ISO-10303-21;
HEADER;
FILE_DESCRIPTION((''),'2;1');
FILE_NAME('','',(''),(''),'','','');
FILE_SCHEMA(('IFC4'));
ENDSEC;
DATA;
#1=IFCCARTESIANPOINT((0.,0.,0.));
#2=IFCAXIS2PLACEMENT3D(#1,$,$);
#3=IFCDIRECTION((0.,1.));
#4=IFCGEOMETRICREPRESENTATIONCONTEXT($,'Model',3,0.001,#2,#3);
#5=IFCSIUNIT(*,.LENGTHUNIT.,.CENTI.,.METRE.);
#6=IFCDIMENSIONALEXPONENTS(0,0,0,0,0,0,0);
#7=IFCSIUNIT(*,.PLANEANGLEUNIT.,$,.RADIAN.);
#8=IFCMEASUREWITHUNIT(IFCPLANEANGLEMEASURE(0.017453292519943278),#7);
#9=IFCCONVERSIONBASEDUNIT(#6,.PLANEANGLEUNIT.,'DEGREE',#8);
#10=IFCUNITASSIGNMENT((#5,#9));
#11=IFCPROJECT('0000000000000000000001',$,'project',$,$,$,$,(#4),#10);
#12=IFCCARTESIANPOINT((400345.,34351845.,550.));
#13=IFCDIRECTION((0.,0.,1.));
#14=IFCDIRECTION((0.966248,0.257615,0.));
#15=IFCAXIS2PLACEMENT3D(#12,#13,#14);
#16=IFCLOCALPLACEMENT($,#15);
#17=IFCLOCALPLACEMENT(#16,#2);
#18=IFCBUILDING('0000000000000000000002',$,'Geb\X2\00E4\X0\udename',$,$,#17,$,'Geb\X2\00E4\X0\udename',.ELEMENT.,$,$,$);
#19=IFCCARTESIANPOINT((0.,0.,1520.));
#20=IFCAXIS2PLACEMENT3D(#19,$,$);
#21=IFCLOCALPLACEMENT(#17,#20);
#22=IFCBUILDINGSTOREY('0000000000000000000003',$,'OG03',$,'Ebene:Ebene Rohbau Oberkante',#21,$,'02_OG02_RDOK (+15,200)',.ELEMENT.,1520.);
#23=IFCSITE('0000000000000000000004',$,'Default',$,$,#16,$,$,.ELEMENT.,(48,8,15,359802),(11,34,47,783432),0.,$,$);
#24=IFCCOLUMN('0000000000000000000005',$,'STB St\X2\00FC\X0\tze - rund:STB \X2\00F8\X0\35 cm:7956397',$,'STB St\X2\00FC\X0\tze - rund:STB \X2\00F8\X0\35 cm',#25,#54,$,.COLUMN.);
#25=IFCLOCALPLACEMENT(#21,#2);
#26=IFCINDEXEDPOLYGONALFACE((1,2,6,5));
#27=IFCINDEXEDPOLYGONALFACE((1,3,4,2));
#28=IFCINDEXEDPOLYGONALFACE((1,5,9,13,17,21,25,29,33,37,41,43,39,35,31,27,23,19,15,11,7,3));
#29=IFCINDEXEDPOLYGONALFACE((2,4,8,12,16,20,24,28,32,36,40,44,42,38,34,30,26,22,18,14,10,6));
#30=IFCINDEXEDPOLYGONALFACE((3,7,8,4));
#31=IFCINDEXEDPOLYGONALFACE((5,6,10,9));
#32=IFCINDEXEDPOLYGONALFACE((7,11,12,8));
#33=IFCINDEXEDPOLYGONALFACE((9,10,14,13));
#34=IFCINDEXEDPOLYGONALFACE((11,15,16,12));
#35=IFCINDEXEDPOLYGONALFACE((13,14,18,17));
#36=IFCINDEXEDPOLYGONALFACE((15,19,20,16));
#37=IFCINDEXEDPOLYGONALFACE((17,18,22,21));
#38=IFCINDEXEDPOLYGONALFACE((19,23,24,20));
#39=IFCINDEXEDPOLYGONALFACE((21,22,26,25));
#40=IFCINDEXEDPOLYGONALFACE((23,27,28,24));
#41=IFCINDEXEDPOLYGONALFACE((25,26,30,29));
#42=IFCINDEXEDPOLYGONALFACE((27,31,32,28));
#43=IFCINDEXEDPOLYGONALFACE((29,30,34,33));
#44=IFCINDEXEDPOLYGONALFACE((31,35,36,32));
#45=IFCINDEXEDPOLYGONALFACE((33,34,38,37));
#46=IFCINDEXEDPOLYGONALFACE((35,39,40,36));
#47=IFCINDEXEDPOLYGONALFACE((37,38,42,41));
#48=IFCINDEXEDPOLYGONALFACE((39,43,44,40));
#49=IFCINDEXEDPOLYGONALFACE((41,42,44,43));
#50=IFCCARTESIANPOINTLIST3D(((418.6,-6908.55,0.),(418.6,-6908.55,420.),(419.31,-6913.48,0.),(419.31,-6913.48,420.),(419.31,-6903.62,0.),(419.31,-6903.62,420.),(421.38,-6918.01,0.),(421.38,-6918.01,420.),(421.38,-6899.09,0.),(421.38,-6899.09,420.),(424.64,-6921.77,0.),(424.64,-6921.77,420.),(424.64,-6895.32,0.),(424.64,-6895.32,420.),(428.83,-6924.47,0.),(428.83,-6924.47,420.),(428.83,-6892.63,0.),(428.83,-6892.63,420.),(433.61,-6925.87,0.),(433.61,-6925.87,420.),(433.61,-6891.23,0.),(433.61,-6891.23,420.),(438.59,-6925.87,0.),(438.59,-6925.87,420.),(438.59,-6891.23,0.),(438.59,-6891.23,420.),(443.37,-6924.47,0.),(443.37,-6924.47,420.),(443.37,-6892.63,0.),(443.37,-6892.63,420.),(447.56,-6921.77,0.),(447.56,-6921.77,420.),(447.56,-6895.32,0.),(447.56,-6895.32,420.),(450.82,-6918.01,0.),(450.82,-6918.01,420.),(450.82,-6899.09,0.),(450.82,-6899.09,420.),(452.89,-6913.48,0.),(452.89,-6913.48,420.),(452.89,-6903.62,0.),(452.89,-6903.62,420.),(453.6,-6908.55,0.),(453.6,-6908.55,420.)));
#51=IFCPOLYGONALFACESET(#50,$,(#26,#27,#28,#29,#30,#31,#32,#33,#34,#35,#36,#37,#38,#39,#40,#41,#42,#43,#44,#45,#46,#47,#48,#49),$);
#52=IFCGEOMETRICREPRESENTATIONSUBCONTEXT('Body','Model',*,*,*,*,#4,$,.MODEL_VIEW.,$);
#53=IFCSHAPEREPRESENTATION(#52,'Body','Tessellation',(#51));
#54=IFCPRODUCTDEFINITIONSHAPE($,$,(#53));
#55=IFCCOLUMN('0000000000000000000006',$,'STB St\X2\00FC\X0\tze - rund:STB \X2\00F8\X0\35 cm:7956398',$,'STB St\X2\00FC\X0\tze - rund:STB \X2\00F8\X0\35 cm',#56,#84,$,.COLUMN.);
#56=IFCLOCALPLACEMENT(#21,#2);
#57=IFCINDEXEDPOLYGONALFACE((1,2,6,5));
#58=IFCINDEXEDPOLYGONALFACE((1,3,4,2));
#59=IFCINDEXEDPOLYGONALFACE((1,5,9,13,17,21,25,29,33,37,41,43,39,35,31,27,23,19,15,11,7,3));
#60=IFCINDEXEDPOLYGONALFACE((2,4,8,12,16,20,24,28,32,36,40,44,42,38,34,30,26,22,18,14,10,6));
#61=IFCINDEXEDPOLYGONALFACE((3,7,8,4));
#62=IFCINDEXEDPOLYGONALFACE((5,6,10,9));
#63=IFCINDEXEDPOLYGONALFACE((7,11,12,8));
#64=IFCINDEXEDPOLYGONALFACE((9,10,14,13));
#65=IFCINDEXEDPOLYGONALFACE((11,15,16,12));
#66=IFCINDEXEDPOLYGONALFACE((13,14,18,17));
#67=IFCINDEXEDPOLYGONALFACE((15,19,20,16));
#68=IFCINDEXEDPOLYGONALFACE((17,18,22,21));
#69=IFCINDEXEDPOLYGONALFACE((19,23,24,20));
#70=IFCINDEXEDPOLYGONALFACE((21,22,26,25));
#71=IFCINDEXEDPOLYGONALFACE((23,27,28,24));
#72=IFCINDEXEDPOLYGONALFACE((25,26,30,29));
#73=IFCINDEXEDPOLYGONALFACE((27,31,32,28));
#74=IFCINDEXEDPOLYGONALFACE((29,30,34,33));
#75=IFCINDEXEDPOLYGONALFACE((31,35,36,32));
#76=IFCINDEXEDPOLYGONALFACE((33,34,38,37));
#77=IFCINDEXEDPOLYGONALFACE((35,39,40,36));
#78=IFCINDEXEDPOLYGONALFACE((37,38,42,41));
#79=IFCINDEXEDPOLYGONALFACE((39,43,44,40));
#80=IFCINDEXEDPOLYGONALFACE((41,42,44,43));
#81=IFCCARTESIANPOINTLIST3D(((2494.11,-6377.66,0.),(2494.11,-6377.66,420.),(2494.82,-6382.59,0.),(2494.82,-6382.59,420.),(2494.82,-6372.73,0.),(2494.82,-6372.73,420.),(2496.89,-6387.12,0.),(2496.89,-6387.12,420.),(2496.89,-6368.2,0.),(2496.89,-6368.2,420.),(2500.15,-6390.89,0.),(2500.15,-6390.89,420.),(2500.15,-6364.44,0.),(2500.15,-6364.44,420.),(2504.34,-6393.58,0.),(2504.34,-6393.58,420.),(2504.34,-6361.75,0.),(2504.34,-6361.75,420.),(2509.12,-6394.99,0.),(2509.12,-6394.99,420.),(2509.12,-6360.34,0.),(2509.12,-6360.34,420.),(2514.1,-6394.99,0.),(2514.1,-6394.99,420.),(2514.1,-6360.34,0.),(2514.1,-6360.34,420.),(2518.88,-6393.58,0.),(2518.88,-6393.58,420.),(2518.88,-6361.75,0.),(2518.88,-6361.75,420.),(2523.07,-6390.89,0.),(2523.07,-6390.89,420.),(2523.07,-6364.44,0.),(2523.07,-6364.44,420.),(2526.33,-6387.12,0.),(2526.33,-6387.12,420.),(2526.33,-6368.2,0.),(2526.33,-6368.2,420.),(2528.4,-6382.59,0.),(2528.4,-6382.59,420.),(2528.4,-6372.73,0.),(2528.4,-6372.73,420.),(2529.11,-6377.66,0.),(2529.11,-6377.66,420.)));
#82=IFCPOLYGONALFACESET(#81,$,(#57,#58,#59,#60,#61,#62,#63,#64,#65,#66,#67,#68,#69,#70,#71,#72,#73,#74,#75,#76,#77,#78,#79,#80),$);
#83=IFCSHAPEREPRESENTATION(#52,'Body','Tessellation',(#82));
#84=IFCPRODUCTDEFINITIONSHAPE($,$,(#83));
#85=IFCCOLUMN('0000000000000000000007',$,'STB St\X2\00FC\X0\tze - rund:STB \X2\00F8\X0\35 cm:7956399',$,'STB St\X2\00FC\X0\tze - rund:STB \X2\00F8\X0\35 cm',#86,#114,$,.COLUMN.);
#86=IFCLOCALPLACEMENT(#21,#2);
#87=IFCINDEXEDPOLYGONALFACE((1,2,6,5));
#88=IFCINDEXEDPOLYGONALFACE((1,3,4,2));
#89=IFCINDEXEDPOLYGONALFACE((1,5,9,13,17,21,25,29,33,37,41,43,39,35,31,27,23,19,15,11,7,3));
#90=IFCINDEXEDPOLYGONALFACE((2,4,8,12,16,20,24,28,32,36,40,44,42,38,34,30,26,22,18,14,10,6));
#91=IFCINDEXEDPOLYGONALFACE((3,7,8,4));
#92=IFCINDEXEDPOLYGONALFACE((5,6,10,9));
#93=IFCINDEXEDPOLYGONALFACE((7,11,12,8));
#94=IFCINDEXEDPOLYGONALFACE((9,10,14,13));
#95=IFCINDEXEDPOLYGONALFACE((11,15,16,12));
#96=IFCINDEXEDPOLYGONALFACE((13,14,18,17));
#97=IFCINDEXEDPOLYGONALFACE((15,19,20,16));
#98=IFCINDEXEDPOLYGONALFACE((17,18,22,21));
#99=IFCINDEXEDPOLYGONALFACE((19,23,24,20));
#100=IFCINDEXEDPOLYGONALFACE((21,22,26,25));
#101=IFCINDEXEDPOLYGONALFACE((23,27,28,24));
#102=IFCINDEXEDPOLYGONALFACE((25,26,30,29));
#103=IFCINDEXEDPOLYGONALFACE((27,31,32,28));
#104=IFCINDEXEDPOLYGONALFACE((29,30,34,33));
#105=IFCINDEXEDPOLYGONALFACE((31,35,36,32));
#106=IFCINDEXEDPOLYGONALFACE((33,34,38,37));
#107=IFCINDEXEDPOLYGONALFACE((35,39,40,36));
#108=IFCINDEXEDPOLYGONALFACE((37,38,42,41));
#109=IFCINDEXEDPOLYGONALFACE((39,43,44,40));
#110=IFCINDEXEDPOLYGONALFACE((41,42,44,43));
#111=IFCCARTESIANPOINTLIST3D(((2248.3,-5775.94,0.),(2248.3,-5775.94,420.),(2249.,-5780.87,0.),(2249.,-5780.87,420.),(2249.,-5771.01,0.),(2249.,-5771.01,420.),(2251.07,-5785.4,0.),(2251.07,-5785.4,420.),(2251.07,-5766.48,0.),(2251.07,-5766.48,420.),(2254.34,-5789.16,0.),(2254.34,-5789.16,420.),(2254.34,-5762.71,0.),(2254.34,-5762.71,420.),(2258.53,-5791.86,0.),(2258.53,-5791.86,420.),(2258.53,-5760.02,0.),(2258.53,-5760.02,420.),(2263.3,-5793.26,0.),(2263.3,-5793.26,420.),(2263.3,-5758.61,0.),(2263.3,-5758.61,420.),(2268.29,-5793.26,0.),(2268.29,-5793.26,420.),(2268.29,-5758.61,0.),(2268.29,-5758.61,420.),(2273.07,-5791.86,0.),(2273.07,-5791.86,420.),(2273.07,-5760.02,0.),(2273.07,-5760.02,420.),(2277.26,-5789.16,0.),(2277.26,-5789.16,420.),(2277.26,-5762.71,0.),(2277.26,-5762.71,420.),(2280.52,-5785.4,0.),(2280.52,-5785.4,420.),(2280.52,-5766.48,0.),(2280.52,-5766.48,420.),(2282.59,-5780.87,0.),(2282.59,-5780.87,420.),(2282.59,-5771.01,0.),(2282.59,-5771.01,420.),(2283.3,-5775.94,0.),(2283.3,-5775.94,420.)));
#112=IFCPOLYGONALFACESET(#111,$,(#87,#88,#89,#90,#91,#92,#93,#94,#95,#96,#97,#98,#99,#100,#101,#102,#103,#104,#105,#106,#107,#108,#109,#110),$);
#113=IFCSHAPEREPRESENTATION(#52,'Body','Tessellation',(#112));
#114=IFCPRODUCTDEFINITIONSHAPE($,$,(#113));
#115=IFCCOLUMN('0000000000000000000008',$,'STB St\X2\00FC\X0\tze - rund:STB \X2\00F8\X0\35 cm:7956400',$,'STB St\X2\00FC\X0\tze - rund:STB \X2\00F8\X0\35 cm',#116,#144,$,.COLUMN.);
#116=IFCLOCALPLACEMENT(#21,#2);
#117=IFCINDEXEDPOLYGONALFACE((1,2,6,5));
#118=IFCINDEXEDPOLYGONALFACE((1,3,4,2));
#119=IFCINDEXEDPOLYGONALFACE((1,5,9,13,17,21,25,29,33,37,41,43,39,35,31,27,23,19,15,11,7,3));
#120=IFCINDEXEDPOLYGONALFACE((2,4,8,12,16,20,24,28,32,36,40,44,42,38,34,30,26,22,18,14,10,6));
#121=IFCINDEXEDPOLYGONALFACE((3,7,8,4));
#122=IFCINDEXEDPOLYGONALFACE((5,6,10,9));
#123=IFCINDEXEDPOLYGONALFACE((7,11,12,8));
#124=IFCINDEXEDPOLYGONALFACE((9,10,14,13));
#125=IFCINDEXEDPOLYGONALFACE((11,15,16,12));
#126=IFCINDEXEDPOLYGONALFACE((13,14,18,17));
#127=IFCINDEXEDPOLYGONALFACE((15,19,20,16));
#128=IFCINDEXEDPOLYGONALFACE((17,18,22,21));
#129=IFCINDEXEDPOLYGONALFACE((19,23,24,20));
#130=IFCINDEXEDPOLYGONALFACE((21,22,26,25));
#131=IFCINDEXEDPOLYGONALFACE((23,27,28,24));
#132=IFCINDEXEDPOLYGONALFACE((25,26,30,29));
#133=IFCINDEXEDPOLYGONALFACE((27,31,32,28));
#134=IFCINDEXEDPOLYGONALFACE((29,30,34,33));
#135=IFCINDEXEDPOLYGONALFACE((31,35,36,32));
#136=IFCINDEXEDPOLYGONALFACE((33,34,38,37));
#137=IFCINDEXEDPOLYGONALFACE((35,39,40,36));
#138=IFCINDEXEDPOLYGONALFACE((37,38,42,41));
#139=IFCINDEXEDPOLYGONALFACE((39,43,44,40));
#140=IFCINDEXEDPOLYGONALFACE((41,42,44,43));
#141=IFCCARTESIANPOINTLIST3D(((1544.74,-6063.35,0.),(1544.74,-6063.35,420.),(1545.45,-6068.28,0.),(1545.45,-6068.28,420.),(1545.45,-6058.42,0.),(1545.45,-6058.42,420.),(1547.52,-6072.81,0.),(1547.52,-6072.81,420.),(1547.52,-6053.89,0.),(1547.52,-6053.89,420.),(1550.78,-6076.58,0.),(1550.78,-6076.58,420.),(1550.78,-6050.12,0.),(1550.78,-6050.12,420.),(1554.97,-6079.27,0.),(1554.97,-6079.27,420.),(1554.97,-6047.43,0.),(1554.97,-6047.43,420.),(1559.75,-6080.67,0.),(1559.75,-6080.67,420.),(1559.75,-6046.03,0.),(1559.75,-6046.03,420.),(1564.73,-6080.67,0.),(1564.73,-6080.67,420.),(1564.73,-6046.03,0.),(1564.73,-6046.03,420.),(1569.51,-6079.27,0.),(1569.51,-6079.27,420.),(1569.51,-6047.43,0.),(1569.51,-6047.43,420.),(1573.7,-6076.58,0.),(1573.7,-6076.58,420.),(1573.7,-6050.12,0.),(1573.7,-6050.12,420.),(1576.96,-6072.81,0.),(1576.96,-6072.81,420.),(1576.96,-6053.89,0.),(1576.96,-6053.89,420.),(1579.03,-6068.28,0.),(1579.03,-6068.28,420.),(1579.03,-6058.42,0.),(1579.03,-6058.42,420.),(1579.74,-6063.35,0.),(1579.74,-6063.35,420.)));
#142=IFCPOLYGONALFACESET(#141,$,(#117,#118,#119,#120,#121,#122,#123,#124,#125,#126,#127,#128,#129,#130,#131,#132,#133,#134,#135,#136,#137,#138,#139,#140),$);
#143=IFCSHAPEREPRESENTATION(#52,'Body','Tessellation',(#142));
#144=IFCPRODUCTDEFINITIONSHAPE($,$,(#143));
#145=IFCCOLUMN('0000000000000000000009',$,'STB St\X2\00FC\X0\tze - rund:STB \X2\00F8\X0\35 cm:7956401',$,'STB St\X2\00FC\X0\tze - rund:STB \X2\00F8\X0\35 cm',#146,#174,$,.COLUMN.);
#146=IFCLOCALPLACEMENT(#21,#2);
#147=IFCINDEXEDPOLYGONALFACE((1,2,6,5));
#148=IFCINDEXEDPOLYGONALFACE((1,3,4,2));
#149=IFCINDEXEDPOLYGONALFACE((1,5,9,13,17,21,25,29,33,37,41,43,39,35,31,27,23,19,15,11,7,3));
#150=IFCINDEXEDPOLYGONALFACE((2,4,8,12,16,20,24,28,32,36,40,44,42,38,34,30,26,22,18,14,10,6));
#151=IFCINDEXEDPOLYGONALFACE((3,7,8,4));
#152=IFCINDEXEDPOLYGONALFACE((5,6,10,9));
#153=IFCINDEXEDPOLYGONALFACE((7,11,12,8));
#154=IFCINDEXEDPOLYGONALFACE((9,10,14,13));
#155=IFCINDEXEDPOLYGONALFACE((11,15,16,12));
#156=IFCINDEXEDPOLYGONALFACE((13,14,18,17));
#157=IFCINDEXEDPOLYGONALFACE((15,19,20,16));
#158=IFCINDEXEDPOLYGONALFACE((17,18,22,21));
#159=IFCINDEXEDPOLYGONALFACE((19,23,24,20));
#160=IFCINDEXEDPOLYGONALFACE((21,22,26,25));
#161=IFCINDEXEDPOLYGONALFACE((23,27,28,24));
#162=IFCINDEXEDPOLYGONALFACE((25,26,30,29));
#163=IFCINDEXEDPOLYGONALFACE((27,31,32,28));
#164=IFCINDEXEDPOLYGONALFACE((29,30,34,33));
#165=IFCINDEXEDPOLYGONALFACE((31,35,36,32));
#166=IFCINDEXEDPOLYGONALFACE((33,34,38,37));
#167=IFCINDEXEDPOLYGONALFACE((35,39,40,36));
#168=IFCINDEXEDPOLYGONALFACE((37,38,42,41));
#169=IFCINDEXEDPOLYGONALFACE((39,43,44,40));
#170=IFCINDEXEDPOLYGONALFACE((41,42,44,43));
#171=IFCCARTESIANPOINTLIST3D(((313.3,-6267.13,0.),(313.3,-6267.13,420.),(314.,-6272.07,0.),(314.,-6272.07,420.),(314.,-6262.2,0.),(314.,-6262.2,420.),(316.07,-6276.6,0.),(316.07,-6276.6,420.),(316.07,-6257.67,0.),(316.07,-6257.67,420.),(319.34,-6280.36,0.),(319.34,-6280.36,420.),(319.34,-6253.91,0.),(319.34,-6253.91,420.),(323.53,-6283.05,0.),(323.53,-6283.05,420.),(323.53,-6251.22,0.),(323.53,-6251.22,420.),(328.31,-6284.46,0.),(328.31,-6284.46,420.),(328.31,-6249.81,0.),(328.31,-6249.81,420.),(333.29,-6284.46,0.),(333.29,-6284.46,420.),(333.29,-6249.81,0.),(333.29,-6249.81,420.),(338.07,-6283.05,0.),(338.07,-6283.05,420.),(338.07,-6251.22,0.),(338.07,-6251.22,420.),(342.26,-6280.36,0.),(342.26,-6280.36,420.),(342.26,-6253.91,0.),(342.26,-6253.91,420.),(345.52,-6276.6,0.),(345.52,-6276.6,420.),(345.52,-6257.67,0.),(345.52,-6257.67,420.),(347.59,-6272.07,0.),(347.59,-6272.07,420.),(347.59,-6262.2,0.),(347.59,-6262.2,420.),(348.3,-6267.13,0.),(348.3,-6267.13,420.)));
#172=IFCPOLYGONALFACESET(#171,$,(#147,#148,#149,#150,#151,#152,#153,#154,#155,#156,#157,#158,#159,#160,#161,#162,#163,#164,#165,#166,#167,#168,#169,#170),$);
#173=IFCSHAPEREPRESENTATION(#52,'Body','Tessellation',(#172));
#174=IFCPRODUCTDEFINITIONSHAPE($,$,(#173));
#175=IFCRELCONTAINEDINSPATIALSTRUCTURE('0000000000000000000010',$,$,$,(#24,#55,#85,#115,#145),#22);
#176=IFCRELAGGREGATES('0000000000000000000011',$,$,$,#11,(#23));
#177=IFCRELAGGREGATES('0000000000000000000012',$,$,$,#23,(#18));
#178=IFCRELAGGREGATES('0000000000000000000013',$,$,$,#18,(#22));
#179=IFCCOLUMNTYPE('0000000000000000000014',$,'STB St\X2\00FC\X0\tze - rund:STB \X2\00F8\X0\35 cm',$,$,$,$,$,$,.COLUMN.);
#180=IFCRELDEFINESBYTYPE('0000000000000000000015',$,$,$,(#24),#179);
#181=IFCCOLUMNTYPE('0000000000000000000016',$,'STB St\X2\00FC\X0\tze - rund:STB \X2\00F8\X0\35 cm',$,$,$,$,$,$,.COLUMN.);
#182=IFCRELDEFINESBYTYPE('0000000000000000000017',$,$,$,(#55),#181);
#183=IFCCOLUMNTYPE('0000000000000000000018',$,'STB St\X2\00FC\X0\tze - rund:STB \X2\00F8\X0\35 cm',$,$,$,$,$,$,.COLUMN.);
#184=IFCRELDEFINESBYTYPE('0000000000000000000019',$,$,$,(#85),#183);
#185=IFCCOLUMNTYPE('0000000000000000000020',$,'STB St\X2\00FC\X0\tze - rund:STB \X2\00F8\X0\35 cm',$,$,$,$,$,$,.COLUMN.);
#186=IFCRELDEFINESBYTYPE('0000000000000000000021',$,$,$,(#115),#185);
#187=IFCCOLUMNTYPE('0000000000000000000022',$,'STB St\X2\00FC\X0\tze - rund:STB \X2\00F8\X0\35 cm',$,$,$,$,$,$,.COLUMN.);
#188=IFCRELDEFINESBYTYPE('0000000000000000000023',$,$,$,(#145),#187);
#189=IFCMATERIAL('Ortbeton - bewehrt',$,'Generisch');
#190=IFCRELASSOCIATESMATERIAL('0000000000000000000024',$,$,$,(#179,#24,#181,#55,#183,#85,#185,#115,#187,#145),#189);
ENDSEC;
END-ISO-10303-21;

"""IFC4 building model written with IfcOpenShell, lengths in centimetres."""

from ifc_helpers import new_model, entity, si_unit, converted_unit, direction, frame, origin, place, context, subcontext, project, spatial, arc, indexed_curve, outline, extrude, source, transform, mapped, material, type_object, type_shapes, element, save


model = new_model("IFC4")

# Units and contexts
model_context = context("Model", 3, precision=0.001, world=origin(), true_north=direction((0.0, 1.0)))
body_context = subcontext(model_context, "Body", "Model", "MODEL_VIEW")
ifc_project = project(units=[si_unit("LENGTHUNIT", "METRE", prefix="CENTI"), converted_unit("PLANEANGLEUNIT", "DEGREE", entity("IfcPlaneAngleMeasure", 0.017453292519943278), si_unit("PLANEANGLEUNIT", "RADIAN"), dimensions=[0, 0, 0, 0, 0, 0, 0])], contexts=[model_context])

# Site, building, storey
site_placement = place(None, frame((400345.0, 34351845.0, 550.0), z_axis=(0.0, 0.0, 1.0), x_axis=(0.966248, 0.257615, 0.0)))
site = spatial("IfcSite", under=ifc_project, at=site_placement, Name="Default", CompositionType="ELEMENT", RefLatitude=(48, 8, 15, 359802), RefLongitude=(11, 34, 47, 783432), RefElevation=0.0)
building_placement = place(site_placement, origin())
building = spatial("IfcBuilding", under=site, at=building_placement, Name="Gebäudename", LongName="Gebäudename", CompositionType="ELEMENT")
storey_placement = place(building_placement, frame((0.0, 0.0, 1520.0)))
storey = spatial("IfcBuildingStorey", under=building, at=storey_placement, Name="OG03", ObjectType="Ebene:Ebene Rohbau Oberkante", LongName="02_OG02_RDOK (+15,200)", CompositionType="ELEMENT", Elevation=1520.0)

# Columns
ifc_material = material(Name="Ortbeton - bewehrt", Category="Generisch")
column_type_1 = type_object("IfcColumnType", Name="STB Stütze - rund:STB ø35 cm", PredefinedType="COLUMN", material=ifc_material)
shared_shape_1 = source(origin(), body_context, "Body", "SweptSolid", [
    extrude(outline(indexed_curve([(-17.5, 0.0), (0.0, -17.5), (17.5, 0.0), (0.0, 17.5)], segments=[arc(1, 2, 3), arc(3, 4, 1)], self_intersect=False)), frame((436.1, -6908.55, 1520.0)), (0.0, 0.0, 1.0), 420.0),
])
type_shapes(column_type_1, [shared_shape_1])
column_1_placement = place(storey_placement, frame((0.0, 0.0, -1520.0)))
element("IfcColumn", 1, at=column_1_placement, inside=storey, type_object=column_type_1, material=ifc_material, Name="STB Stütze - rund:STB ø35 cm:7956397", ObjectType="STB Stütze - rund:STB ø35 cm", PredefinedType="COLUMN", context=body_context, shape_type="MappedRepresentation", body=[
    mapped(shared_shape_1, transform((0.0, 0.0, 0.0), scale=1.0)),
])
column_type_2 = type_object("IfcColumnType", Name="STB Stütze - rund:STB ø35 cm", PredefinedType="COLUMN", material=ifc_material)
shared_shape_2 = source(origin(), body_context, "Body", "SweptSolid", [
    extrude(outline(indexed_curve([(-17.5, 0.0), (0.0, -17.5), (17.5, 0.0), (0.0, 17.5)], segments=[arc(1, 2, 3), arc(3, 4, 1)], self_intersect=False)), frame((2511.61, -6377.66, 1520.0)), (0.0, 0.0, 1.0), 420.0),
])
type_shapes(column_type_2, [shared_shape_2])
column_2_placement = place(storey_placement, frame((0.0, 0.0, -1520.0)))
element("IfcColumn", 2, at=column_2_placement, inside=storey, type_object=column_type_2, material=ifc_material, Name="STB Stütze - rund:STB ø35 cm:7956398", ObjectType="STB Stütze - rund:STB ø35 cm", PredefinedType="COLUMN", context=body_context, shape_type="MappedRepresentation", body=[
    mapped(shared_shape_2, transform((0.0, 0.0, 0.0), scale=1.0)),
])
column_type_3 = type_object("IfcColumnType", Name="STB Stütze - rund:STB ø35 cm", PredefinedType="COLUMN", material=ifc_material)
shared_shape_3 = source(origin(), body_context, "Body", "SweptSolid", [
    extrude(outline(indexed_curve([(-17.5, 0.0), (0.0, -17.5), (17.5, 0.0), (0.0, 17.5)], segments=[arc(1, 2, 3), arc(3, 4, 1)], self_intersect=False)), frame((2265.8, -5775.94, 1520.0)), (0.0, 0.0, 1.0), 420.0),
])
type_shapes(column_type_3, [shared_shape_3])
column_3_placement = place(storey_placement, frame((0.0, 0.0, -1520.0)))
element("IfcColumn", 3, at=column_3_placement, inside=storey, type_object=column_type_3, material=ifc_material, Name="STB Stütze - rund:STB ø35 cm:7956399", ObjectType="STB Stütze - rund:STB ø35 cm", PredefinedType="COLUMN", context=body_context, shape_type="MappedRepresentation", body=[
    mapped(shared_shape_3, transform((0.0, 0.0, 0.0), scale=1.0)),
])
column_type_4 = type_object("IfcColumnType", Name="STB Stütze - rund:STB ø35 cm", PredefinedType="COLUMN", material=ifc_material)
shared_shape_4 = source(origin(), body_context, "Body", "SweptSolid", [
    extrude(outline(indexed_curve([(-17.5, 0.0), (0.0, -17.5), (17.5, 0.0), (0.0, 17.5)], segments=[arc(1, 2, 3), arc(3, 4, 1)], self_intersect=False)), frame((1562.24, -6063.35, 1520.0)), (0.0, 0.0, 1.0), 420.0),
])
type_shapes(column_type_4, [shared_shape_4])
column_4_placement = place(storey_placement, frame((0.0, 0.0, -1520.0)))
element("IfcColumn", 4, at=column_4_placement, inside=storey, type_object=column_type_4, material=ifc_material, Name="STB Stütze - rund:STB ø35 cm:7956400", ObjectType="STB Stütze - rund:STB ø35 cm", PredefinedType="COLUMN", context=body_context, shape_type="MappedRepresentation", body=[
    mapped(shared_shape_4, transform((0.0, 0.0, 0.0), scale=1.0)),
])
column_type_5 = type_object("IfcColumnType", Name="STB Stütze - rund:STB ø35 cm", PredefinedType="COLUMN", material=ifc_material)
shared_shape_5 = source(origin(), body_context, "Body", "SweptSolid", [
    extrude(outline(indexed_curve([(-17.5, 0.0), (0.0, -17.5), (17.5, 0.0), (0.0, 17.5)], segments=[arc(1, 2, 3), arc(3, 4, 1)], self_intersect=False)), frame((330.8, -6267.13, 1520.0)), (0.0, 0.0, 1.0), 420.0),
])
type_shapes(column_type_5, [shared_shape_5])
column_5_placement = place(storey_placement, frame((0.0, 0.0, -1520.0)))
element("IfcColumn", 5, at=column_5_placement, inside=storey, type_object=column_type_5, material=ifc_material, Name="STB Stütze - rund:STB ø35 cm:7956401", ObjectType="STB Stütze - rund:STB ø35 cm", PredefinedType="COLUMN", context=body_context, shape_type="MappedRepresentation", body=[
    mapped(shared_shape_5, transform((0.0, 0.0, 0.0), scale=1.0)),
])

save(model, "model.ifc")
